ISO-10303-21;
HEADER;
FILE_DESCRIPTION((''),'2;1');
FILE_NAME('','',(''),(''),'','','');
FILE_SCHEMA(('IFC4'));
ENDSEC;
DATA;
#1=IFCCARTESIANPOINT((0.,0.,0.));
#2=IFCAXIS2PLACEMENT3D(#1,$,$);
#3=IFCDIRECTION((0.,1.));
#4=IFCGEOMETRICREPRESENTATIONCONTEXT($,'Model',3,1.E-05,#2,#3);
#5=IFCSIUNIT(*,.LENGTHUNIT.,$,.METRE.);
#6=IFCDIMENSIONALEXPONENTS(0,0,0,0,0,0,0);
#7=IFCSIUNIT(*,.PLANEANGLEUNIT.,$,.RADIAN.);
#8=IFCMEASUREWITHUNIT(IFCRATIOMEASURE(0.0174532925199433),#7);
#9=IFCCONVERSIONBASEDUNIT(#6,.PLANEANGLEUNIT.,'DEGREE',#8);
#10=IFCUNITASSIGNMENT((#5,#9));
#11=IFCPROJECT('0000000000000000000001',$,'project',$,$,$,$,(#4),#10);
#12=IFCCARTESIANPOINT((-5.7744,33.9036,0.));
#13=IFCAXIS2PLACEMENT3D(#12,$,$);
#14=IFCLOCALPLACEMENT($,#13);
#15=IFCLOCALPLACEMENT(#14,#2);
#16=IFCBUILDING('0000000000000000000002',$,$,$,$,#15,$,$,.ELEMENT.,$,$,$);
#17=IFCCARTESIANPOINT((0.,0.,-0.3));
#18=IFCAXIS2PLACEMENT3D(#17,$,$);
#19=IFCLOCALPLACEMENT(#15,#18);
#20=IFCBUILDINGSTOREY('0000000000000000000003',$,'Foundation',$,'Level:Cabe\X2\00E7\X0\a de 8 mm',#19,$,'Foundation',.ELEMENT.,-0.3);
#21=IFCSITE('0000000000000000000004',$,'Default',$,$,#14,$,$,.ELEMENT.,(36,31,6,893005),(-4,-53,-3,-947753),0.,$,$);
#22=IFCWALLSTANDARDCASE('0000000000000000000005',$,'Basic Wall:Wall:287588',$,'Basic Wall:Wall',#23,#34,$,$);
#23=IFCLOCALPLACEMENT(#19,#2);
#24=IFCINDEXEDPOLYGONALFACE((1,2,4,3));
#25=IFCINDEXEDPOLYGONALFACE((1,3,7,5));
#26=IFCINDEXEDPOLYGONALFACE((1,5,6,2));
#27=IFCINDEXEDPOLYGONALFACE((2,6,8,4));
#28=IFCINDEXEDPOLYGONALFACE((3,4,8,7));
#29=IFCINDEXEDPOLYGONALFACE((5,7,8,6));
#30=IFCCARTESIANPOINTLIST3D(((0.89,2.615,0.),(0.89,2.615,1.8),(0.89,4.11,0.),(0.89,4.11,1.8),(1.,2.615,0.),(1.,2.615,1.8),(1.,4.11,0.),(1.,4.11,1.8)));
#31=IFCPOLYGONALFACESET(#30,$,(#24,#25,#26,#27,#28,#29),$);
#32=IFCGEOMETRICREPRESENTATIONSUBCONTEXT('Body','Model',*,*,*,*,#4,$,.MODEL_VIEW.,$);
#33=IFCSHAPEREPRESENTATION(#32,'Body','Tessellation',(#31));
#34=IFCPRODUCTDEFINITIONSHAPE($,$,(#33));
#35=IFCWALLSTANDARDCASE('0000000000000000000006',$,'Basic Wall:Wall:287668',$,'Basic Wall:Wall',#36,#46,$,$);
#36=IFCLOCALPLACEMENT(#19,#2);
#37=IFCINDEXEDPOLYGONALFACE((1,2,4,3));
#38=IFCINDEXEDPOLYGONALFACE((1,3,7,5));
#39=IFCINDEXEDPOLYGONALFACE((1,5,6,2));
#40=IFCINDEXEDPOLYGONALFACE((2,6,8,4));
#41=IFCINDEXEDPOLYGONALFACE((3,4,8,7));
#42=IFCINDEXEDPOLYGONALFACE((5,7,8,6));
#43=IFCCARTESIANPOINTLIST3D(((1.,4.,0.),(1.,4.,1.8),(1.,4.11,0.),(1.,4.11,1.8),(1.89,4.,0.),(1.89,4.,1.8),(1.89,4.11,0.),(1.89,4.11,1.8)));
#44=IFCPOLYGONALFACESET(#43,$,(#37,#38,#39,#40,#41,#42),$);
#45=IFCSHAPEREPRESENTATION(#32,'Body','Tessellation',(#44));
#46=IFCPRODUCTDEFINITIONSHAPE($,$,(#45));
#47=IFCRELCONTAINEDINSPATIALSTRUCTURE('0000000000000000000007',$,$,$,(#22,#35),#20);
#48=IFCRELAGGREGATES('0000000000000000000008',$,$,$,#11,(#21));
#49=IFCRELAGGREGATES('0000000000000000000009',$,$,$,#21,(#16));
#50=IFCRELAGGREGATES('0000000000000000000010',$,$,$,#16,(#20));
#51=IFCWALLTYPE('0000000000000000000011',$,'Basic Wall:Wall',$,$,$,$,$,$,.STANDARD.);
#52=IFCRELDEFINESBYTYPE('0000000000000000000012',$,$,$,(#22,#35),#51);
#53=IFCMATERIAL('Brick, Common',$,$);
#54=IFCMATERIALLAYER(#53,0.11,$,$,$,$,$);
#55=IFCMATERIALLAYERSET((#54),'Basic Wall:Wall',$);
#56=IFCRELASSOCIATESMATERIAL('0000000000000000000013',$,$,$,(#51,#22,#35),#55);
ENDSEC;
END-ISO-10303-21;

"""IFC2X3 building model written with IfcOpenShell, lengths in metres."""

from ifc_helpers import new_model, entity, si_unit, converted_unit, direction, frame, frame_2d, origin, place, context, subcontext, project, spatial, rectangle, extrude, material, layer, layer_set, layer_usage, type_object, element, save


model = new_model("IFC2X3")

# Units and contexts
model_context = context("Model", 3, precision=1e-05, world=origin(), true_north=direction((0.0, 1.0)))
body_context = subcontext(model_context, "Body", "Model", "MODEL_VIEW")
ifc_project = project(units=[si_unit("LENGTHUNIT", "METRE"), converted_unit("PLANEANGLEUNIT", "DEGREE", entity("IfcRatioMeasure", 0.0174532925199433), si_unit("PLANEANGLEUNIT", "RADIAN"), dimensions=[0, 0, 0, 0, 0, 0, 0])], contexts=[model_context])

# Site, building, storey
site_placement = place(None, frame((-5.7744, 33.9036, 0.0)))
site = spatial("IfcSite", under=ifc_project, at=site_placement, Name="Default", CompositionType="ELEMENT", RefLatitude=(36, 31, 6, 893005), RefLongitude=(-4, -53, -3, -947753), RefElevation=0.0)
building_placement = place(site_placement, origin())
building = spatial("IfcBuilding", under=site, at=building_placement, CompositionType="ELEMENT")
storey_placement = place(building_placement, frame((0.0, 0.0, -0.3)))
storey = spatial("IfcBuildingStorey", under=building, at=storey_placement, Name="Foundation", ObjectType="Level:Cabeça de 8 mm", LongName="Foundation", CompositionType="ELEMENT", Elevation=-0.3)

# Walls
ifc_material = material(Name="Brick, Common")
ifc_layer = layer(ifc_material, 0.11)
ifc_layer_set = layer_set([ifc_layer], Name="Basic Wall:Wall")
ifc_layer_usage_1 = layer_usage(ifc_layer_set, "AXIS2", "NEGATIVE", 0.055)
wall_type = type_object("IfcWallType", Name="Basic Wall:Wall", PredefinedType="STANDARD", material=ifc_layer_set)
wall_1_placement = place(storey_placement, frame((0.945, 2.615, 0.0), z_axis=(0.0, 0.0, 1.0), x_axis=(0.0, 1.0, 0.0)))
element("IfcWallStandardCase", 1, at=wall_1_placement, inside=storey, type_object=wall_type, material=ifc_layer_usage_1, Name="Basic Wall:Wall:287588", ObjectType="Basic Wall:Wall", context=body_context, shape_type="SweptSolid", body=[
    extrude(rectangle(XDim=1.495, YDim=0.11, at=frame_2d((0.7475, 0.0), x_axis=(-1.0, 0.0))), origin(), (0.0, 0.0, 1.0), 1.8),
])
ifc_layer_usage_2 = layer_usage(ifc_layer_set, "AXIS2", "NEGATIVE", 0.055)
wall_2_placement = place(storey_placement, frame((1.0, 4.055, 0.0)))
element("IfcWallStandardCase", 2, at=wall_2_placement, inside=storey, type_object=wall_type, material=ifc_layer_usage_2, Name="Basic Wall:Wall:287668", ObjectType="Basic Wall:Wall", context=body_context, shape_type="SweptSolid", body=[
    extrude(rectangle(XDim=0.89, YDim=0.11, at=frame_2d((0.445, 0.0), x_axis=(-1.0, 0.0))), origin(), (0.0, 0.0, 1.0), 1.8),
])

save(model, "model.ifc")
